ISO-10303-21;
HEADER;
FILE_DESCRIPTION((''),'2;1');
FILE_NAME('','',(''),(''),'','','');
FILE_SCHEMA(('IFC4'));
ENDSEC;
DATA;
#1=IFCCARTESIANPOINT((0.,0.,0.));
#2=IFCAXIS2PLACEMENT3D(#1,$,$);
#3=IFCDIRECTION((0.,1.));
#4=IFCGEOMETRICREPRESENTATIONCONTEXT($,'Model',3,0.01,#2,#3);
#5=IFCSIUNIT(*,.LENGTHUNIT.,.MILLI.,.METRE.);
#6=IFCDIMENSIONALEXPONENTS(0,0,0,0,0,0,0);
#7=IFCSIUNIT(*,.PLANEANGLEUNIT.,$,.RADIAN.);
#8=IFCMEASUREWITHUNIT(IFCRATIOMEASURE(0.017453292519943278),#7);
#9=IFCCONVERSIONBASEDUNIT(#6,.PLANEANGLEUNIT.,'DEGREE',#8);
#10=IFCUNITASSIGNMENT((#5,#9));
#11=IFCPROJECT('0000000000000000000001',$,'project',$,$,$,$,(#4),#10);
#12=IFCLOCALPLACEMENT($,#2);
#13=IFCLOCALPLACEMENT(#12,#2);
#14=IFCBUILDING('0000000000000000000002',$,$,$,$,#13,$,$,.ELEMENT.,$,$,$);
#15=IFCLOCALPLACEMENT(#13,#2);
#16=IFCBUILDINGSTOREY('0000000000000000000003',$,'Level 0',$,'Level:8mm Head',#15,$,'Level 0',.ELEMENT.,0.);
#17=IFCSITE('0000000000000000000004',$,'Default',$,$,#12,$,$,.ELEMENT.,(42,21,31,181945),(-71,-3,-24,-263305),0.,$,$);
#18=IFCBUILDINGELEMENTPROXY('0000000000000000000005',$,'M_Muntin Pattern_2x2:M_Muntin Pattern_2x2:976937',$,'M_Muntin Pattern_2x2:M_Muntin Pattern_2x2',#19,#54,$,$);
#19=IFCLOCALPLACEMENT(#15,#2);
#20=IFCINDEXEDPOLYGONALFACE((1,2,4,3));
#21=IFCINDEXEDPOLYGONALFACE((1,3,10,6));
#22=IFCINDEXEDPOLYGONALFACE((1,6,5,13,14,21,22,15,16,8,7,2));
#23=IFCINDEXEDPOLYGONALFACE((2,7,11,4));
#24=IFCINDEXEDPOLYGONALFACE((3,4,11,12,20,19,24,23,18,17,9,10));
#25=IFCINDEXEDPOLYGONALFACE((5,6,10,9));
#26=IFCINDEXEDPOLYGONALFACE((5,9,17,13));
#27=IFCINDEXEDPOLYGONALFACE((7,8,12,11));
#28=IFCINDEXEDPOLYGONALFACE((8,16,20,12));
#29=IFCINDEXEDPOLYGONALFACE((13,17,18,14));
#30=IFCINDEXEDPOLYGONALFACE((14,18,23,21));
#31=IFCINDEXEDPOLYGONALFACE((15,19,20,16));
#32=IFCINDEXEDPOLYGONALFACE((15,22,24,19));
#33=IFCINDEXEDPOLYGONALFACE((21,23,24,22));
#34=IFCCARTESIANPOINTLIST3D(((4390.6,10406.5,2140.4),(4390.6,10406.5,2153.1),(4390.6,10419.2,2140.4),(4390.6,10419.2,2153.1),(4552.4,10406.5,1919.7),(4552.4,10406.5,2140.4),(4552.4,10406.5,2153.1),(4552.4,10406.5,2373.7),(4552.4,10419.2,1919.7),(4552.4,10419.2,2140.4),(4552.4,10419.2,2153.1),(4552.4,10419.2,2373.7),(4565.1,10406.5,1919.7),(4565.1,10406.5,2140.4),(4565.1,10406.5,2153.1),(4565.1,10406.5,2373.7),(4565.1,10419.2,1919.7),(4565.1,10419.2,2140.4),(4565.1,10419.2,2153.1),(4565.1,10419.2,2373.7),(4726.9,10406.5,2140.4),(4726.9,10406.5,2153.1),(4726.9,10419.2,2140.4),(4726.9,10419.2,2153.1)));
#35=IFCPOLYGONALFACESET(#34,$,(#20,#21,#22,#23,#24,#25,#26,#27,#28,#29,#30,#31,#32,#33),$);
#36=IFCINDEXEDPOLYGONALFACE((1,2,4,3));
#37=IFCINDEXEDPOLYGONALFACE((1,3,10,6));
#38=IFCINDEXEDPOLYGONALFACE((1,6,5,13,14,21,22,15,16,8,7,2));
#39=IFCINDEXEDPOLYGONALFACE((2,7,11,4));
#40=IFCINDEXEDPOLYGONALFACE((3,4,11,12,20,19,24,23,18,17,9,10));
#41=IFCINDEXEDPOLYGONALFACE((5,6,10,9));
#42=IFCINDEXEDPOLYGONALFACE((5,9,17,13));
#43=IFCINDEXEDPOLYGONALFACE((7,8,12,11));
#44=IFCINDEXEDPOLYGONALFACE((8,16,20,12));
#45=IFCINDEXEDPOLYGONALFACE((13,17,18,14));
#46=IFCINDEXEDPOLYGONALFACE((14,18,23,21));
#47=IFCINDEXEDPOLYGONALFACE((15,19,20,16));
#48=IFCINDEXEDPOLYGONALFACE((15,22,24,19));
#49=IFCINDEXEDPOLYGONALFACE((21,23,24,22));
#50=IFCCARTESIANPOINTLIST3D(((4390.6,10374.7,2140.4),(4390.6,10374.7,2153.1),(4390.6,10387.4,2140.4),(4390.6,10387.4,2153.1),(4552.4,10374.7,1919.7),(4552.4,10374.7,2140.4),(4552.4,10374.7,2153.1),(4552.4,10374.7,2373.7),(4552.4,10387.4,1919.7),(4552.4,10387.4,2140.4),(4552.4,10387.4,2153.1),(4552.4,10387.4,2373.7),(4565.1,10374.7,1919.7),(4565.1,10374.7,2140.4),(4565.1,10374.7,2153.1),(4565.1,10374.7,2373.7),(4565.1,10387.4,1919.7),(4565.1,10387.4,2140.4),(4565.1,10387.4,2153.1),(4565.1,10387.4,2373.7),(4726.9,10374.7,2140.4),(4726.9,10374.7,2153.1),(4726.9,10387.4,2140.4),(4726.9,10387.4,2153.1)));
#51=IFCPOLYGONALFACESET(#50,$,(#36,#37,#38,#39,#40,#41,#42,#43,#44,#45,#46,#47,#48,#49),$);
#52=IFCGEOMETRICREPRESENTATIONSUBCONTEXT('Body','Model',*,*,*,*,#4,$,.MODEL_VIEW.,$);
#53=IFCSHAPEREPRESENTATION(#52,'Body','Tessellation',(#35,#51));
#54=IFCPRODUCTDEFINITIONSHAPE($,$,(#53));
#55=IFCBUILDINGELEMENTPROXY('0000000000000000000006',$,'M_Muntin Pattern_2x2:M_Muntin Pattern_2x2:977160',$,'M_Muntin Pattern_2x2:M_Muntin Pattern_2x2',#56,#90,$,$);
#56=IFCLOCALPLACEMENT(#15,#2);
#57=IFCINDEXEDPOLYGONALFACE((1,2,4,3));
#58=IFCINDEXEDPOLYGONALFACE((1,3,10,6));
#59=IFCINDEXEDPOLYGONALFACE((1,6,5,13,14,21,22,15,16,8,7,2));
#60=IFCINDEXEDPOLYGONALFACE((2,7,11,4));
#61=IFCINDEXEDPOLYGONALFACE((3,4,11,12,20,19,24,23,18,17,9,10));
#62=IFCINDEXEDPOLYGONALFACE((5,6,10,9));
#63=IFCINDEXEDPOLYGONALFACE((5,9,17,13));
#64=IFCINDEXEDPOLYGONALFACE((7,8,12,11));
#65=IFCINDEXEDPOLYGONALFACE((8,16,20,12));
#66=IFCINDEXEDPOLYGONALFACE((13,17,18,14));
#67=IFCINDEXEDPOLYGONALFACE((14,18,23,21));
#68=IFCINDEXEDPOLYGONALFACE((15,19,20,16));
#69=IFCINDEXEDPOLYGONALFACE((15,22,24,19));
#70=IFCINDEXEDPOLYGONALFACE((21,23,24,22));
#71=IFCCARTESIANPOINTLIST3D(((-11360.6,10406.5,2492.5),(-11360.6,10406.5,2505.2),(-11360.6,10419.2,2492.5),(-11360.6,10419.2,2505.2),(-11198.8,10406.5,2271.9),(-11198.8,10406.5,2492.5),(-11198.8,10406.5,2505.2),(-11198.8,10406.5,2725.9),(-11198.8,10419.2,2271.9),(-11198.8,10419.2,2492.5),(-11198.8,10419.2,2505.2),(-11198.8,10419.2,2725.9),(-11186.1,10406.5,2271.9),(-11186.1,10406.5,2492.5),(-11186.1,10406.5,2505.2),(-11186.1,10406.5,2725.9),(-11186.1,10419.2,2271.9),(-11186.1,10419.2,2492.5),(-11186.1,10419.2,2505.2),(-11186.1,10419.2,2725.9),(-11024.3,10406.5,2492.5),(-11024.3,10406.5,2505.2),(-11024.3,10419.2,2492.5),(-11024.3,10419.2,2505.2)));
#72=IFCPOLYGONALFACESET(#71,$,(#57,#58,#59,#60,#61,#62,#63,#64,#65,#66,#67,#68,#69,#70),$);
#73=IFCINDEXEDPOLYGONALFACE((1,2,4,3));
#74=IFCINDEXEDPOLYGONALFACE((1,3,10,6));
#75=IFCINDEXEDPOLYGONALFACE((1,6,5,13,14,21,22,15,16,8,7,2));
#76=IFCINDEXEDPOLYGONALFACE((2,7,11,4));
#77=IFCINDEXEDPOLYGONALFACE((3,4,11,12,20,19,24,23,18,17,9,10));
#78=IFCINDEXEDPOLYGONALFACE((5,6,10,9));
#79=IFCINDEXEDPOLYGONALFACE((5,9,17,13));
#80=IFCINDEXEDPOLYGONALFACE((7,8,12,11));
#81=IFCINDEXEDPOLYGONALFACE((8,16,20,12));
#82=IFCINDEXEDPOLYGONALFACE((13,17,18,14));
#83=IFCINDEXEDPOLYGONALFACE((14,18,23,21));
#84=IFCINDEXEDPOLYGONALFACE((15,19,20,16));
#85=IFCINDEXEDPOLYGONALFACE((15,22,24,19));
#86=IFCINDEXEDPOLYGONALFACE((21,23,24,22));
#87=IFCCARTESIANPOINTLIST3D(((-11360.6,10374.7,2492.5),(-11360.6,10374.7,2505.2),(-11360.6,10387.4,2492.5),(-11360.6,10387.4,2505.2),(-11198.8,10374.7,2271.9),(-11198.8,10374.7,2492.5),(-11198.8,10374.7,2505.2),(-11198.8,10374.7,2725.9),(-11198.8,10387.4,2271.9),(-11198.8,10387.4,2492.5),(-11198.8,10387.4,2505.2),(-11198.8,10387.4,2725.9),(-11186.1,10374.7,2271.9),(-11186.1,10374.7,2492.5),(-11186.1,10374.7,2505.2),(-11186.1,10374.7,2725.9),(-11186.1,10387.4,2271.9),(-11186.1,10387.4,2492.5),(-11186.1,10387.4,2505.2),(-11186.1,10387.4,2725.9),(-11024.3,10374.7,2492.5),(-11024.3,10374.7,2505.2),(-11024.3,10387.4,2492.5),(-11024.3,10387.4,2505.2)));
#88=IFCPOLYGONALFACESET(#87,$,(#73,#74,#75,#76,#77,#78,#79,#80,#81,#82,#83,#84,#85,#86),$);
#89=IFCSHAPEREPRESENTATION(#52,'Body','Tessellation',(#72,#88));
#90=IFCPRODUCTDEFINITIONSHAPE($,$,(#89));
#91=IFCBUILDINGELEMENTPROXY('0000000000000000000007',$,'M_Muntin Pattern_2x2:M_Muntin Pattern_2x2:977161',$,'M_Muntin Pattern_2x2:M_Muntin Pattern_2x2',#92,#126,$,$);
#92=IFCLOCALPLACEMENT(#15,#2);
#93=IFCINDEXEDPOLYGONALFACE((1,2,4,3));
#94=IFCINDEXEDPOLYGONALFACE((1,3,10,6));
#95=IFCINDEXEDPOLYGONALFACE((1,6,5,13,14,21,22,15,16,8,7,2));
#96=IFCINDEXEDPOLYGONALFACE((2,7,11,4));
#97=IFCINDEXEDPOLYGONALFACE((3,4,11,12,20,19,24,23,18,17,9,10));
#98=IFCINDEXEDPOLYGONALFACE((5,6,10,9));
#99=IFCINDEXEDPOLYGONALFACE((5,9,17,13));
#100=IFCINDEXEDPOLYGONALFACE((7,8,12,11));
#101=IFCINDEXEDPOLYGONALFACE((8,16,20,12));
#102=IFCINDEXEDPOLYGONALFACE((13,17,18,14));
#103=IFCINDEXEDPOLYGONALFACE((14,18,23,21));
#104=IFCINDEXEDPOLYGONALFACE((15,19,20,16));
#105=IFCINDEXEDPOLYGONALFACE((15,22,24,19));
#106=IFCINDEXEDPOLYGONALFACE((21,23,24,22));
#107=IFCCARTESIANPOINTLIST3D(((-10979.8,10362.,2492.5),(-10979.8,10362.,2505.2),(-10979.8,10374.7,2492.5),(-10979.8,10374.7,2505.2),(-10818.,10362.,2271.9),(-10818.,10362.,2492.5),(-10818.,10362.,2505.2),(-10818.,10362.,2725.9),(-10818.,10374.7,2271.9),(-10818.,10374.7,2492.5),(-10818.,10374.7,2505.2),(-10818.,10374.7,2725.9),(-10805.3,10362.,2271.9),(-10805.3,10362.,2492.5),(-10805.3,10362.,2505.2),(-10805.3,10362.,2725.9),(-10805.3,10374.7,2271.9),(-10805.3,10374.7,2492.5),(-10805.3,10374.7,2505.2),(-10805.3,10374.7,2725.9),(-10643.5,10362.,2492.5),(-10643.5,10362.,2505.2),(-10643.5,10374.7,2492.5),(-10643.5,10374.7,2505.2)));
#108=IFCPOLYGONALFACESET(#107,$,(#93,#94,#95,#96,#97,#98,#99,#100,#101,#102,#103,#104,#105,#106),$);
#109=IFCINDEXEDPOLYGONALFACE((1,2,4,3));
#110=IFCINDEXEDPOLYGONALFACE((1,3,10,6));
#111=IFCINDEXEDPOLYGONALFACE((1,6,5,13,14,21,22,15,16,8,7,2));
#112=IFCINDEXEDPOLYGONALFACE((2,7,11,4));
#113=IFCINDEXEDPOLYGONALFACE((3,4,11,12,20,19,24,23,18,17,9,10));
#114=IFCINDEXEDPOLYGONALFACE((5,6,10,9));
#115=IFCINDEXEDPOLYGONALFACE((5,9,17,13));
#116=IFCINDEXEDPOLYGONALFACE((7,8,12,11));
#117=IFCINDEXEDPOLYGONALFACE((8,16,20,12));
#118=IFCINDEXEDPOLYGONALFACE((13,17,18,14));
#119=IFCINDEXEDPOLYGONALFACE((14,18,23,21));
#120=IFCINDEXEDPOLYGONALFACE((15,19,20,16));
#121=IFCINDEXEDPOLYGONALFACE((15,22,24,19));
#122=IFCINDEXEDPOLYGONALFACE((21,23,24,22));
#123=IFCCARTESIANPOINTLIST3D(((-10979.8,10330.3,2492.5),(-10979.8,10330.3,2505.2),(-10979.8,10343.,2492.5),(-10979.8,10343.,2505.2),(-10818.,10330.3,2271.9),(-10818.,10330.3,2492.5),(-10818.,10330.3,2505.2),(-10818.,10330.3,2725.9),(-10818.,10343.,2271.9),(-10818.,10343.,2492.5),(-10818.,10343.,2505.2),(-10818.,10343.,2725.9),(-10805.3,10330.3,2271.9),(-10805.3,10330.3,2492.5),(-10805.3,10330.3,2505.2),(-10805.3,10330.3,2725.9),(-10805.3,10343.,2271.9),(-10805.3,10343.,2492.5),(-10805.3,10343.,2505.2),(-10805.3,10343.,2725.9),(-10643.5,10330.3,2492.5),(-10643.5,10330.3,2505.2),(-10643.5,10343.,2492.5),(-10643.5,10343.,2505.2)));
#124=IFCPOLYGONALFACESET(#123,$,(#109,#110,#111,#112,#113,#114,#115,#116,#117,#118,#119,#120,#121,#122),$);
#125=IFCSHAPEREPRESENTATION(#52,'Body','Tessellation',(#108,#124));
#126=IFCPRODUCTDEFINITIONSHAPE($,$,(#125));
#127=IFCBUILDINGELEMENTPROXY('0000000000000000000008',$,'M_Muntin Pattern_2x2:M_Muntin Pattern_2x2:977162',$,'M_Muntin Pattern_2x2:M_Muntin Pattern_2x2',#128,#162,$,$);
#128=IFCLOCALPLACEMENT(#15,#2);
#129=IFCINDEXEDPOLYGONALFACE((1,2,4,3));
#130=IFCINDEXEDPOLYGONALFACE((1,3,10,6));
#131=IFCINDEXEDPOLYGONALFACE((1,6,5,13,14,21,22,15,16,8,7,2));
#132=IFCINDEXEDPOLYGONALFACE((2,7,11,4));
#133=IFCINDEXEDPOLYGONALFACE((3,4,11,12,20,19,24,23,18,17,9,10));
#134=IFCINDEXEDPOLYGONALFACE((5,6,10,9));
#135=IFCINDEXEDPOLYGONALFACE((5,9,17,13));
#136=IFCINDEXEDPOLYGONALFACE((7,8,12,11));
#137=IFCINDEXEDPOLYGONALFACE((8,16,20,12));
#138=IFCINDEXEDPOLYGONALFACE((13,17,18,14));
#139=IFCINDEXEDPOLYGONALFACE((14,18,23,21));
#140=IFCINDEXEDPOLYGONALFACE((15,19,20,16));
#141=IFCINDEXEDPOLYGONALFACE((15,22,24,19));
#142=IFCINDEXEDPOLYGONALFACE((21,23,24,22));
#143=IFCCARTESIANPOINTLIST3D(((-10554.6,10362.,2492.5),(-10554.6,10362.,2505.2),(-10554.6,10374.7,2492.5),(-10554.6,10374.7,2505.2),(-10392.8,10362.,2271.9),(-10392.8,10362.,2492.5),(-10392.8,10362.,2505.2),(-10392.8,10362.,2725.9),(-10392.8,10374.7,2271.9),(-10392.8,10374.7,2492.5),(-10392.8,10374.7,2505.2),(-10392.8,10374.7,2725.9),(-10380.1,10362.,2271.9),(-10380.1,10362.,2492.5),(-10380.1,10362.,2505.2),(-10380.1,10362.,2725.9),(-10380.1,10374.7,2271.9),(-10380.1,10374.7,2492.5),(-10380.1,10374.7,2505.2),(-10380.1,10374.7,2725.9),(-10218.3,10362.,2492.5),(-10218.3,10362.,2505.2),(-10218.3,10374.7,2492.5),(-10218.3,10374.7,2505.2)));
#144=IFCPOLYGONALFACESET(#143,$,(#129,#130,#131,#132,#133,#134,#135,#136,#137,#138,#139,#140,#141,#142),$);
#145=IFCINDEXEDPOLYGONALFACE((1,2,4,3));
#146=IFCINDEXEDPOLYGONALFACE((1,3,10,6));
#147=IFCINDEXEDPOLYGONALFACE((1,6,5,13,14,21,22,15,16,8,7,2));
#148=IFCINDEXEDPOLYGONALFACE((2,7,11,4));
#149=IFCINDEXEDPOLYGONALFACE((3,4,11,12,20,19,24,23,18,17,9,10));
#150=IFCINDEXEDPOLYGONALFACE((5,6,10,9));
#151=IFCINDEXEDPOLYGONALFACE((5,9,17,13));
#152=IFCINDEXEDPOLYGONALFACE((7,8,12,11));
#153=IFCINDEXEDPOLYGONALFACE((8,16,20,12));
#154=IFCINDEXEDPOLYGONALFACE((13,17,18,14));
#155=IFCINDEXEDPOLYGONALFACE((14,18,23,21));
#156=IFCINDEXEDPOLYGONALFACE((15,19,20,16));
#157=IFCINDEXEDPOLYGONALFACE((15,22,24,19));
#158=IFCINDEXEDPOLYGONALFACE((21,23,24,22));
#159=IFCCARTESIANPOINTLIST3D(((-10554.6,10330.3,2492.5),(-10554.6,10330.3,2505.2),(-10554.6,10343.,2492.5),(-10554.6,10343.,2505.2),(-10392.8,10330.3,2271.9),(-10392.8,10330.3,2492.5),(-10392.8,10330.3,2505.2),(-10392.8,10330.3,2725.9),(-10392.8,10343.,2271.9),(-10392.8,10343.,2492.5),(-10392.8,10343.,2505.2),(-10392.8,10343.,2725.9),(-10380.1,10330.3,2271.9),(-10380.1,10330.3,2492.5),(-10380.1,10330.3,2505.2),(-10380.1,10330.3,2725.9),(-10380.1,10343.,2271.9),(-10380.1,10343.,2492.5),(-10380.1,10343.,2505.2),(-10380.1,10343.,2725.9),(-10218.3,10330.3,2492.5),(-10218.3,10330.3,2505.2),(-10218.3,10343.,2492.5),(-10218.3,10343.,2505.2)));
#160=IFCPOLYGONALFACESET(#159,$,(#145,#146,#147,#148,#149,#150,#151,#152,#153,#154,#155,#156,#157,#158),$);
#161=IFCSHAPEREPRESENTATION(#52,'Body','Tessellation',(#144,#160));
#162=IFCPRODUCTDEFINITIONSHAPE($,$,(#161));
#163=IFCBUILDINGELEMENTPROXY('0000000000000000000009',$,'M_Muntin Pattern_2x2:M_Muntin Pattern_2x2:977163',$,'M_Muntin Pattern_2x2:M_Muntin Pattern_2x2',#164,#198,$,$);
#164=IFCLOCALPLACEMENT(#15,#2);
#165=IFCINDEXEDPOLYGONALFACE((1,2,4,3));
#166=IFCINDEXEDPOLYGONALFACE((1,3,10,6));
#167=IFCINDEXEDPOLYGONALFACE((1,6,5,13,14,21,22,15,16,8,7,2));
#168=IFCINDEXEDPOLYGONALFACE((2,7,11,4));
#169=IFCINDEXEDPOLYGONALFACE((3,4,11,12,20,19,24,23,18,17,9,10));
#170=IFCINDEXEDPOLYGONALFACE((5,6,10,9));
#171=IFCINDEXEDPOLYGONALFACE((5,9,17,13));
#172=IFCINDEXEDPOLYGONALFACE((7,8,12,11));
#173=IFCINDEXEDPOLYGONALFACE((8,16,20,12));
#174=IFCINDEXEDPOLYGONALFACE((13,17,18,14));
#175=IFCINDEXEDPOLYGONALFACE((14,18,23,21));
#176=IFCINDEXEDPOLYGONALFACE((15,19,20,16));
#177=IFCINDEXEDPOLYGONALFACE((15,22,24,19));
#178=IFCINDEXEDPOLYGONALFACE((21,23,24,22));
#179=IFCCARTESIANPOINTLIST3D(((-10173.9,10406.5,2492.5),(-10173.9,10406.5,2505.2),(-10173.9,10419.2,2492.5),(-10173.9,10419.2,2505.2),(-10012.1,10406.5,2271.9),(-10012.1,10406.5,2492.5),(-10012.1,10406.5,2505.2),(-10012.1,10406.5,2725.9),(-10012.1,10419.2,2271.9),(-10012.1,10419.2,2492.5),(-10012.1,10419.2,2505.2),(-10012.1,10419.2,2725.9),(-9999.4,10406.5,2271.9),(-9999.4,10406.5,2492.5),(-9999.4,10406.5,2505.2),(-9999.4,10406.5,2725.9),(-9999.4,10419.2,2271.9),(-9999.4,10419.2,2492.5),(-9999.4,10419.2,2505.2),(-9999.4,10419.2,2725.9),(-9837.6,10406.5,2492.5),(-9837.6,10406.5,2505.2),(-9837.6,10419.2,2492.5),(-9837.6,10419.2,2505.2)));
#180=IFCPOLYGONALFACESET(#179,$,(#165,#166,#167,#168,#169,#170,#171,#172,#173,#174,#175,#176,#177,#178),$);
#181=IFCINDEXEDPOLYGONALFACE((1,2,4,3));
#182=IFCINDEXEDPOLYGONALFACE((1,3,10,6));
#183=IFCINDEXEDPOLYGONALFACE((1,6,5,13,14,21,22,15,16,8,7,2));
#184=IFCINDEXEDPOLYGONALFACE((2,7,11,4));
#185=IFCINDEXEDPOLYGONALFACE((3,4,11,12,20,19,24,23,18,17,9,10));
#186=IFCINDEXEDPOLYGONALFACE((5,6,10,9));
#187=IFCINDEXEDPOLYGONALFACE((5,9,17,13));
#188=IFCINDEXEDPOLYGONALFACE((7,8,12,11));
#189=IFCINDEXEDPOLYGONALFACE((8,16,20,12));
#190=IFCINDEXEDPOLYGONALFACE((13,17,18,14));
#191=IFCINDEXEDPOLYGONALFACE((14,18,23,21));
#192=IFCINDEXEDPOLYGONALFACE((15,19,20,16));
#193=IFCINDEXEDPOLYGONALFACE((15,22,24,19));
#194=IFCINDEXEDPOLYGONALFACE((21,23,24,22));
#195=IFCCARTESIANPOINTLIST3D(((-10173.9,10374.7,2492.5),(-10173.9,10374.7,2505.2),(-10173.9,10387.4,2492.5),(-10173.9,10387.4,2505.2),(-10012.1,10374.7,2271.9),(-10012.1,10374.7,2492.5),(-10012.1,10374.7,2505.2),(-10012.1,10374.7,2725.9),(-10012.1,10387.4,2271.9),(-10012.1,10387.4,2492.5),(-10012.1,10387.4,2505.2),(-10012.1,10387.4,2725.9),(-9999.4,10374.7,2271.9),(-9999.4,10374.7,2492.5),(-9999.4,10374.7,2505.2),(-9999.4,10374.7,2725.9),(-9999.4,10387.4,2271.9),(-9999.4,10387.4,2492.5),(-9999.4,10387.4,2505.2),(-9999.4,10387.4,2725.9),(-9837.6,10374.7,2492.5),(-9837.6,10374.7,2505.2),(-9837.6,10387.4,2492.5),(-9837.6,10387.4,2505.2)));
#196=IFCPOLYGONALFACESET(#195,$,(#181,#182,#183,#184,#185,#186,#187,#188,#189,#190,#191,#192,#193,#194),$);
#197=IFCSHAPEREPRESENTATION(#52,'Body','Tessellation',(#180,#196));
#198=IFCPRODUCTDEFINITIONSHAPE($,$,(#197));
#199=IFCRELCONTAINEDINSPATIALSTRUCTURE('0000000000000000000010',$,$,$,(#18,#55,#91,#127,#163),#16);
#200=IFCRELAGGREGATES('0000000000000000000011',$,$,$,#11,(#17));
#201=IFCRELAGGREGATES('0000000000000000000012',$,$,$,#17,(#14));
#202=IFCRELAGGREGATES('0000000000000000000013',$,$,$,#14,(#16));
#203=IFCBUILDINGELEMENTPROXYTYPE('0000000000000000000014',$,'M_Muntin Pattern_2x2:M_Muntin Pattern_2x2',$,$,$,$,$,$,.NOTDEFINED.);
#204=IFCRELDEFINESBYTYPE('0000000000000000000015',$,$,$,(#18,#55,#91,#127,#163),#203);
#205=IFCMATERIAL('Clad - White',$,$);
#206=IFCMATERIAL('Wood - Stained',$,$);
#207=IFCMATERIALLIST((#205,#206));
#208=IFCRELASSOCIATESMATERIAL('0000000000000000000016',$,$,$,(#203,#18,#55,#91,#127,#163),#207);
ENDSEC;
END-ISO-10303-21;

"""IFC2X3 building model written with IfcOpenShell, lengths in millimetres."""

from ifc_helpers import new_model, entity, si_unit, converted_unit, direction, frame, origin, place, context, subcontext, project, spatial, polyline, outline, extrude, source, transform, mapped, material, material_list, type_object, type_shapes, element, save


model = new_model("IFC2X3")

# Units and contexts
model_context = context("Model", 3, precision=0.01, world=origin(), true_north=direction((0.0, 1.0)))
body_context = subcontext(model_context, "Body", "Model", "MODEL_VIEW")
ifc_project = project(units=[si_unit("LENGTHUNIT", "METRE", prefix="MILLI"), converted_unit("PLANEANGLEUNIT", "DEGREE", entity("IfcRatioMeasure", 0.017453292519943278), si_unit("PLANEANGLEUNIT", "RADIAN"), dimensions=[0, 0, 0, 0, 0, 0, 0])], contexts=[model_context])

# Site, building, storey
site_placement = place(None, origin())
site = spatial("IfcSite", under=ifc_project, at=site_placement, Name="Default", CompositionType="ELEMENT", RefLatitude=(42, 21, 31, 181945), RefLongitude=(-71, -3, -24, -263305), RefElevation=0.0)
building_placement = place(site_placement, origin())
building = spatial("IfcBuilding", under=site, at=building_placement, CompositionType="ELEMENT")
storey_placement = place(building_placement, origin())
storey = spatial("IfcBuildingStorey", under=building, at=storey_placement, Name="Level 0", ObjectType="Level:8mm Head", LongName="Level 0", CompositionType="ELEMENT", Elevation=0.0)

# Building element proxies
ifc_material_1 = material(Name="Clad - White")
ifc_material_2 = material(Name="Wood - Stained")
ifc_material_list = material_list([ifc_material_1, ifc_material_2])
building_element_proxy_type_1 = type_object("IfcBuildingElementProxyType", Name="M_Muntin Pattern_2x2:M_Muntin Pattern_2x2", PredefinedType="NOTDEFINED", material=ifc_material_list)
shared_shape_1 = source(origin(), body_context, "Body", "SweptSolid", [
    extrude(outline(polyline([(6.4, -6.4), (227.0, -6.4), (227.0, 6.3), (6.4, 6.3), (6.4, 168.2), (-6.3, 168.2), (-6.3, 6.3), (-227.0, 6.3), (-227.0, -6.4), (-6.3, -6.4), (-6.3, -168.1), (6.4, -168.1), (6.4, -6.4)])), frame((0.0, 9.5, 227.0), z_axis=(0.0, 1.0, 0.0), x_axis=(0.0, 0.0, 1.0)), (0.0, 0.0, 1.0), 12.7),
    extrude(outline(polyline([(6.4, -6.4), (227.0, -6.4), (227.0, 6.3), (6.4, 6.3), (6.4, 168.2), (-6.3, 168.2), (-6.3, 6.3), (-227.0, 6.3), (-227.0, -6.4), (-6.3, -6.4), (-6.3, -168.1), (6.4, -168.1), (6.4, -6.4)])), frame((0.0, -22.2, 227.0), z_axis=(0.0, 1.0, 0.0), x_axis=(0.0, 0.0, 1.0)), (0.0, 0.0, 1.0), 12.7),
])
type_shapes(building_element_proxy_type_1, [shared_shape_1])
for number, where, name in (
    (1, (4558.8, 10396.9, 1919.7), "M_Muntin Pattern_2x2:M_Muntin Pattern_2x2:976937"),
    (2, (-11192.4, 10396.9, 2271.9), "M_Muntin Pattern_2x2:M_Muntin Pattern_2x2:977160"),
    (3, (-10811.7, 10352.5, 2271.9), "M_Muntin Pattern_2x2:M_Muntin Pattern_2x2:977161"),
    (4, (-10386.5, 10352.5, 2271.9), "M_Muntin Pattern_2x2:M_Muntin Pattern_2x2:977162"),
    (5, (-10005.7, 10396.9, 2271.9), "M_Muntin Pattern_2x2:M_Muntin Pattern_2x2:977163"),
):
    element("IfcBuildingElementProxy", number, at=place(storey_placement, frame(where)), inside=storey, type_object=building_element_proxy_type_1, material=ifc_material_list, Name=name, ObjectType="M_Muntin Pattern_2x2:M_Muntin Pattern_2x2", context=body_context, shape_type="MappedRepresentation", body=[
        mapped(shared_shape_1, transform((0.0, 0.0, 0.0), scale=1.0)),
    ])

save(model, "model.ifc")
